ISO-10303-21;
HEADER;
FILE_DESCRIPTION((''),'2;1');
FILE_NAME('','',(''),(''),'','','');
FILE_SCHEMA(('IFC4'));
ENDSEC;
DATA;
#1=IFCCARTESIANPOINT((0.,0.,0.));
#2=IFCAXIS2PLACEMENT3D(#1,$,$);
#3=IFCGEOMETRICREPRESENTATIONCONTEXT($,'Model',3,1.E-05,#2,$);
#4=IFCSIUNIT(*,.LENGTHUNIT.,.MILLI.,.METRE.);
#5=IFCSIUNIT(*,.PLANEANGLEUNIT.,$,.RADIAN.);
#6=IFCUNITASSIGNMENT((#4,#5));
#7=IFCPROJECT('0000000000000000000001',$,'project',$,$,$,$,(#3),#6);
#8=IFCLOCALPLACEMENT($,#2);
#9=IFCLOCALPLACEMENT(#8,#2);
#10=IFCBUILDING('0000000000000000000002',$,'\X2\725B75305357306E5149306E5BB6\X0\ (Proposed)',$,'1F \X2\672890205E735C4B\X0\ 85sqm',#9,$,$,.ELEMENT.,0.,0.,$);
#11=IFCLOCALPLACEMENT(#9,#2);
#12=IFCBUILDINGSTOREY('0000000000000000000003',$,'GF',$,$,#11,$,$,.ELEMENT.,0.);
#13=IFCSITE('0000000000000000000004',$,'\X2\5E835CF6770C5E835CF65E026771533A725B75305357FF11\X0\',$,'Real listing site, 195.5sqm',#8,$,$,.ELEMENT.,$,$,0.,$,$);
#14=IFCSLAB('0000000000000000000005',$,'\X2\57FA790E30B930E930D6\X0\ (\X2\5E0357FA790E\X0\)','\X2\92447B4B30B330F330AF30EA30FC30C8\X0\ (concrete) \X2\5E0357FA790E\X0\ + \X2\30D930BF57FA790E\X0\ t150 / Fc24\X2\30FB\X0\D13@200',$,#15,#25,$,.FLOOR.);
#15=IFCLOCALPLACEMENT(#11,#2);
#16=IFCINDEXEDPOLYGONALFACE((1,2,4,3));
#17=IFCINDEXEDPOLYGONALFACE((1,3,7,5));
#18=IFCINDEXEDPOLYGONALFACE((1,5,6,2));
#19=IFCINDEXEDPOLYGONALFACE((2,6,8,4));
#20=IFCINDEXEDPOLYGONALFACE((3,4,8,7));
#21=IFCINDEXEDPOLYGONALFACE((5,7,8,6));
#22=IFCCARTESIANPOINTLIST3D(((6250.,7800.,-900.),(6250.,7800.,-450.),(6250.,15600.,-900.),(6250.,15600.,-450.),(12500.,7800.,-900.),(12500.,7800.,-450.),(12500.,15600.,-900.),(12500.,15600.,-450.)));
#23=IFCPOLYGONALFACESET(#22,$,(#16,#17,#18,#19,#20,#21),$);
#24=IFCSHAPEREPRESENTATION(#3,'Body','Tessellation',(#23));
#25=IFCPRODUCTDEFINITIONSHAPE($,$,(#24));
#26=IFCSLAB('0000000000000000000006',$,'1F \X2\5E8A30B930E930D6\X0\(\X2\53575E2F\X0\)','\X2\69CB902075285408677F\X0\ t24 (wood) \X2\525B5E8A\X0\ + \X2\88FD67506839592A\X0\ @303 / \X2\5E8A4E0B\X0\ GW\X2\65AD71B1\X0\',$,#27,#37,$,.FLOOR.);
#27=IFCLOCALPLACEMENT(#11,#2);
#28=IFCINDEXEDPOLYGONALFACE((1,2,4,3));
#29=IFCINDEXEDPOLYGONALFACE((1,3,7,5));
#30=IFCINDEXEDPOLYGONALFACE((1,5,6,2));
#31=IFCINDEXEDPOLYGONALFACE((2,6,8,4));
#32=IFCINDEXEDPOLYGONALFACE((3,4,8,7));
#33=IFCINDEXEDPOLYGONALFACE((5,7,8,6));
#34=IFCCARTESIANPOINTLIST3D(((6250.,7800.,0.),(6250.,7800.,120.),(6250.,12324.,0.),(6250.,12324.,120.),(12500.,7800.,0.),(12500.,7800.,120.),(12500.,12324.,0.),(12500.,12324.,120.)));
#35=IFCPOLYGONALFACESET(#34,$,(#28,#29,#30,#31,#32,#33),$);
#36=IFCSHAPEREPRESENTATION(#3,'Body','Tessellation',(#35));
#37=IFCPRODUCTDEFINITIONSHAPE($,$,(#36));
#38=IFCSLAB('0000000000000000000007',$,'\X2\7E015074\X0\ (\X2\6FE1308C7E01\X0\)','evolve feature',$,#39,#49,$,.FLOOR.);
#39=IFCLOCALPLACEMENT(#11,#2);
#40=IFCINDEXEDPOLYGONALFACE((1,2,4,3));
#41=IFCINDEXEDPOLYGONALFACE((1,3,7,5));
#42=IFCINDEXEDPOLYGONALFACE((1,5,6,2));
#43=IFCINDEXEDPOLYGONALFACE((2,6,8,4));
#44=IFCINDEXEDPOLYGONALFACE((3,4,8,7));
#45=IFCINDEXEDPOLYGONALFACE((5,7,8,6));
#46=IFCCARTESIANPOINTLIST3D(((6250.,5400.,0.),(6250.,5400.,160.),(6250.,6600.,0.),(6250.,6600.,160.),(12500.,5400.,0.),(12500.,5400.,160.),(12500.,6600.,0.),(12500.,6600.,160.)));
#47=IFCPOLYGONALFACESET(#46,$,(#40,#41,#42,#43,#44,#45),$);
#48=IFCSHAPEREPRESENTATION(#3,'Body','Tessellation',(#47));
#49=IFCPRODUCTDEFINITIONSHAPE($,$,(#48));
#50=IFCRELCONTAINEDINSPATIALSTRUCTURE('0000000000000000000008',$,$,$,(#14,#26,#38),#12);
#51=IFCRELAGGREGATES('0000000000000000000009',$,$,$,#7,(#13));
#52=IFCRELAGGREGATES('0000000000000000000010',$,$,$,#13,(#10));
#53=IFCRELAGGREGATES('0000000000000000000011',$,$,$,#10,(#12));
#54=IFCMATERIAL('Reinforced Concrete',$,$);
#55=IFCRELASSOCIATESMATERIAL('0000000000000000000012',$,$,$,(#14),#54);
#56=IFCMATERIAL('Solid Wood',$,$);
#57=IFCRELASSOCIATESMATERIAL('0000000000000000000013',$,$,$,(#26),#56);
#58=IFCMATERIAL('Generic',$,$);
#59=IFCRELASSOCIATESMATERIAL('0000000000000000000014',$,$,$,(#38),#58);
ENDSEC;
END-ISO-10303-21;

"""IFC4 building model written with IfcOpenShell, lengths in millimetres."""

from ifc_helpers import new_model, si_unit, frame, frame_2d, origin, place, context, project, spatial, rectangle, extrude, material, element, save


model = new_model("IFC4")

# Units and contexts
model_context = context("Model", 3, precision=1e-05, world=origin())
ifc_project = project(units=[si_unit("LENGTHUNIT", "METRE", prefix="MILLI"), si_unit("PLANEANGLEUNIT", "RADIAN")], contexts=[model_context])

# Site, building, storey
site_placement = place(None, origin())
site = spatial("IfcSite", under=ifc_project, at=site_placement, Name="広島県広島市東区牛田南１", ObjectType="Real listing site, 195.5sqm", CompositionType="ELEMENT", RefElevation=0.0)
building_placement = place(site_placement, origin())
building = spatial("IfcBuilding", under=site, at=building_placement, Name="牛田南の光の家 (Proposed)", ObjectType="1F 木造平屋 85sqm", CompositionType="ELEMENT", ElevationOfRefHeight=0.0, ElevationOfTerrain=0.0)
storey_placement = place(building_placement, origin())
storey = spatial("IfcBuildingStorey", under=building, at=storey_placement, Name="GF", CompositionType="ELEMENT", Elevation=0.0)

# Slabs
ifc_material_1 = material(Name="Reinforced Concrete")
slab_1_placement = place(storey_placement, frame((3125.0, 3900.0, -450.0)))
element("IfcSlab", 1, at=slab_1_placement, inside=storey, material=ifc_material_1, Name="基礎スラブ (布基礎)", Description="鉄筋コンクリート (concrete) 布基礎 + ベタ基礎 t150 / Fc24・D13@200", PredefinedType="FLOOR", context=model_context, shape_type="SweptSolid", body=[
    extrude(rectangle(XDim=6250.0, YDim=7800.0, at=frame_2d((3125.0, 3900.0))), frame((3125.0, 3900.0, -450.0)), (0.0, 0.0, 1.0), 450.0),
])
ifc_material_2 = material(Name="Solid Wood")
slab_2_placement = place(storey_placement, frame((3125.0, 3900.0, 0.0)))
element("IfcSlab", 2, at=slab_2_placement, inside=storey, material=ifc_material_2, Name="1F 床スラブ(南帯)", Description="構造用合板 t24 (wood) 剛床 + 製材根太 @303 / 床下 GW断熱", PredefinedType="FLOOR", context=model_context, shape_type="SweptSolid", body=[
    extrude(rectangle(XDim=6250.0, YDim=4524.0, at=frame_2d((3125.0, 2262.0))), frame((3125.0, 3900.0, 0.0)), (0.0, 0.0, 1.0), 120.0),
])
ifc_material_3 = material(Name="Generic")
slab_3_placement = place(storey_placement, frame((3125.0, 2700.0, 0.0)))
element("IfcSlab", 3, at=slab_3_placement, inside=storey, material=ifc_material_3, Name="縁側 (濡れ縁)", Description="evolve feature", PredefinedType="FLOOR", context=model_context, shape_type="SweptSolid", body=[
    extrude(rectangle(XDim=6250.0, YDim=1200.0, at=frame_2d((3125.0, 600.0))), frame((3125.0, 2700.0, 0.0)), (0.0, 0.0, 1.0), 160.0),
])

save(model, "model.ifc")
